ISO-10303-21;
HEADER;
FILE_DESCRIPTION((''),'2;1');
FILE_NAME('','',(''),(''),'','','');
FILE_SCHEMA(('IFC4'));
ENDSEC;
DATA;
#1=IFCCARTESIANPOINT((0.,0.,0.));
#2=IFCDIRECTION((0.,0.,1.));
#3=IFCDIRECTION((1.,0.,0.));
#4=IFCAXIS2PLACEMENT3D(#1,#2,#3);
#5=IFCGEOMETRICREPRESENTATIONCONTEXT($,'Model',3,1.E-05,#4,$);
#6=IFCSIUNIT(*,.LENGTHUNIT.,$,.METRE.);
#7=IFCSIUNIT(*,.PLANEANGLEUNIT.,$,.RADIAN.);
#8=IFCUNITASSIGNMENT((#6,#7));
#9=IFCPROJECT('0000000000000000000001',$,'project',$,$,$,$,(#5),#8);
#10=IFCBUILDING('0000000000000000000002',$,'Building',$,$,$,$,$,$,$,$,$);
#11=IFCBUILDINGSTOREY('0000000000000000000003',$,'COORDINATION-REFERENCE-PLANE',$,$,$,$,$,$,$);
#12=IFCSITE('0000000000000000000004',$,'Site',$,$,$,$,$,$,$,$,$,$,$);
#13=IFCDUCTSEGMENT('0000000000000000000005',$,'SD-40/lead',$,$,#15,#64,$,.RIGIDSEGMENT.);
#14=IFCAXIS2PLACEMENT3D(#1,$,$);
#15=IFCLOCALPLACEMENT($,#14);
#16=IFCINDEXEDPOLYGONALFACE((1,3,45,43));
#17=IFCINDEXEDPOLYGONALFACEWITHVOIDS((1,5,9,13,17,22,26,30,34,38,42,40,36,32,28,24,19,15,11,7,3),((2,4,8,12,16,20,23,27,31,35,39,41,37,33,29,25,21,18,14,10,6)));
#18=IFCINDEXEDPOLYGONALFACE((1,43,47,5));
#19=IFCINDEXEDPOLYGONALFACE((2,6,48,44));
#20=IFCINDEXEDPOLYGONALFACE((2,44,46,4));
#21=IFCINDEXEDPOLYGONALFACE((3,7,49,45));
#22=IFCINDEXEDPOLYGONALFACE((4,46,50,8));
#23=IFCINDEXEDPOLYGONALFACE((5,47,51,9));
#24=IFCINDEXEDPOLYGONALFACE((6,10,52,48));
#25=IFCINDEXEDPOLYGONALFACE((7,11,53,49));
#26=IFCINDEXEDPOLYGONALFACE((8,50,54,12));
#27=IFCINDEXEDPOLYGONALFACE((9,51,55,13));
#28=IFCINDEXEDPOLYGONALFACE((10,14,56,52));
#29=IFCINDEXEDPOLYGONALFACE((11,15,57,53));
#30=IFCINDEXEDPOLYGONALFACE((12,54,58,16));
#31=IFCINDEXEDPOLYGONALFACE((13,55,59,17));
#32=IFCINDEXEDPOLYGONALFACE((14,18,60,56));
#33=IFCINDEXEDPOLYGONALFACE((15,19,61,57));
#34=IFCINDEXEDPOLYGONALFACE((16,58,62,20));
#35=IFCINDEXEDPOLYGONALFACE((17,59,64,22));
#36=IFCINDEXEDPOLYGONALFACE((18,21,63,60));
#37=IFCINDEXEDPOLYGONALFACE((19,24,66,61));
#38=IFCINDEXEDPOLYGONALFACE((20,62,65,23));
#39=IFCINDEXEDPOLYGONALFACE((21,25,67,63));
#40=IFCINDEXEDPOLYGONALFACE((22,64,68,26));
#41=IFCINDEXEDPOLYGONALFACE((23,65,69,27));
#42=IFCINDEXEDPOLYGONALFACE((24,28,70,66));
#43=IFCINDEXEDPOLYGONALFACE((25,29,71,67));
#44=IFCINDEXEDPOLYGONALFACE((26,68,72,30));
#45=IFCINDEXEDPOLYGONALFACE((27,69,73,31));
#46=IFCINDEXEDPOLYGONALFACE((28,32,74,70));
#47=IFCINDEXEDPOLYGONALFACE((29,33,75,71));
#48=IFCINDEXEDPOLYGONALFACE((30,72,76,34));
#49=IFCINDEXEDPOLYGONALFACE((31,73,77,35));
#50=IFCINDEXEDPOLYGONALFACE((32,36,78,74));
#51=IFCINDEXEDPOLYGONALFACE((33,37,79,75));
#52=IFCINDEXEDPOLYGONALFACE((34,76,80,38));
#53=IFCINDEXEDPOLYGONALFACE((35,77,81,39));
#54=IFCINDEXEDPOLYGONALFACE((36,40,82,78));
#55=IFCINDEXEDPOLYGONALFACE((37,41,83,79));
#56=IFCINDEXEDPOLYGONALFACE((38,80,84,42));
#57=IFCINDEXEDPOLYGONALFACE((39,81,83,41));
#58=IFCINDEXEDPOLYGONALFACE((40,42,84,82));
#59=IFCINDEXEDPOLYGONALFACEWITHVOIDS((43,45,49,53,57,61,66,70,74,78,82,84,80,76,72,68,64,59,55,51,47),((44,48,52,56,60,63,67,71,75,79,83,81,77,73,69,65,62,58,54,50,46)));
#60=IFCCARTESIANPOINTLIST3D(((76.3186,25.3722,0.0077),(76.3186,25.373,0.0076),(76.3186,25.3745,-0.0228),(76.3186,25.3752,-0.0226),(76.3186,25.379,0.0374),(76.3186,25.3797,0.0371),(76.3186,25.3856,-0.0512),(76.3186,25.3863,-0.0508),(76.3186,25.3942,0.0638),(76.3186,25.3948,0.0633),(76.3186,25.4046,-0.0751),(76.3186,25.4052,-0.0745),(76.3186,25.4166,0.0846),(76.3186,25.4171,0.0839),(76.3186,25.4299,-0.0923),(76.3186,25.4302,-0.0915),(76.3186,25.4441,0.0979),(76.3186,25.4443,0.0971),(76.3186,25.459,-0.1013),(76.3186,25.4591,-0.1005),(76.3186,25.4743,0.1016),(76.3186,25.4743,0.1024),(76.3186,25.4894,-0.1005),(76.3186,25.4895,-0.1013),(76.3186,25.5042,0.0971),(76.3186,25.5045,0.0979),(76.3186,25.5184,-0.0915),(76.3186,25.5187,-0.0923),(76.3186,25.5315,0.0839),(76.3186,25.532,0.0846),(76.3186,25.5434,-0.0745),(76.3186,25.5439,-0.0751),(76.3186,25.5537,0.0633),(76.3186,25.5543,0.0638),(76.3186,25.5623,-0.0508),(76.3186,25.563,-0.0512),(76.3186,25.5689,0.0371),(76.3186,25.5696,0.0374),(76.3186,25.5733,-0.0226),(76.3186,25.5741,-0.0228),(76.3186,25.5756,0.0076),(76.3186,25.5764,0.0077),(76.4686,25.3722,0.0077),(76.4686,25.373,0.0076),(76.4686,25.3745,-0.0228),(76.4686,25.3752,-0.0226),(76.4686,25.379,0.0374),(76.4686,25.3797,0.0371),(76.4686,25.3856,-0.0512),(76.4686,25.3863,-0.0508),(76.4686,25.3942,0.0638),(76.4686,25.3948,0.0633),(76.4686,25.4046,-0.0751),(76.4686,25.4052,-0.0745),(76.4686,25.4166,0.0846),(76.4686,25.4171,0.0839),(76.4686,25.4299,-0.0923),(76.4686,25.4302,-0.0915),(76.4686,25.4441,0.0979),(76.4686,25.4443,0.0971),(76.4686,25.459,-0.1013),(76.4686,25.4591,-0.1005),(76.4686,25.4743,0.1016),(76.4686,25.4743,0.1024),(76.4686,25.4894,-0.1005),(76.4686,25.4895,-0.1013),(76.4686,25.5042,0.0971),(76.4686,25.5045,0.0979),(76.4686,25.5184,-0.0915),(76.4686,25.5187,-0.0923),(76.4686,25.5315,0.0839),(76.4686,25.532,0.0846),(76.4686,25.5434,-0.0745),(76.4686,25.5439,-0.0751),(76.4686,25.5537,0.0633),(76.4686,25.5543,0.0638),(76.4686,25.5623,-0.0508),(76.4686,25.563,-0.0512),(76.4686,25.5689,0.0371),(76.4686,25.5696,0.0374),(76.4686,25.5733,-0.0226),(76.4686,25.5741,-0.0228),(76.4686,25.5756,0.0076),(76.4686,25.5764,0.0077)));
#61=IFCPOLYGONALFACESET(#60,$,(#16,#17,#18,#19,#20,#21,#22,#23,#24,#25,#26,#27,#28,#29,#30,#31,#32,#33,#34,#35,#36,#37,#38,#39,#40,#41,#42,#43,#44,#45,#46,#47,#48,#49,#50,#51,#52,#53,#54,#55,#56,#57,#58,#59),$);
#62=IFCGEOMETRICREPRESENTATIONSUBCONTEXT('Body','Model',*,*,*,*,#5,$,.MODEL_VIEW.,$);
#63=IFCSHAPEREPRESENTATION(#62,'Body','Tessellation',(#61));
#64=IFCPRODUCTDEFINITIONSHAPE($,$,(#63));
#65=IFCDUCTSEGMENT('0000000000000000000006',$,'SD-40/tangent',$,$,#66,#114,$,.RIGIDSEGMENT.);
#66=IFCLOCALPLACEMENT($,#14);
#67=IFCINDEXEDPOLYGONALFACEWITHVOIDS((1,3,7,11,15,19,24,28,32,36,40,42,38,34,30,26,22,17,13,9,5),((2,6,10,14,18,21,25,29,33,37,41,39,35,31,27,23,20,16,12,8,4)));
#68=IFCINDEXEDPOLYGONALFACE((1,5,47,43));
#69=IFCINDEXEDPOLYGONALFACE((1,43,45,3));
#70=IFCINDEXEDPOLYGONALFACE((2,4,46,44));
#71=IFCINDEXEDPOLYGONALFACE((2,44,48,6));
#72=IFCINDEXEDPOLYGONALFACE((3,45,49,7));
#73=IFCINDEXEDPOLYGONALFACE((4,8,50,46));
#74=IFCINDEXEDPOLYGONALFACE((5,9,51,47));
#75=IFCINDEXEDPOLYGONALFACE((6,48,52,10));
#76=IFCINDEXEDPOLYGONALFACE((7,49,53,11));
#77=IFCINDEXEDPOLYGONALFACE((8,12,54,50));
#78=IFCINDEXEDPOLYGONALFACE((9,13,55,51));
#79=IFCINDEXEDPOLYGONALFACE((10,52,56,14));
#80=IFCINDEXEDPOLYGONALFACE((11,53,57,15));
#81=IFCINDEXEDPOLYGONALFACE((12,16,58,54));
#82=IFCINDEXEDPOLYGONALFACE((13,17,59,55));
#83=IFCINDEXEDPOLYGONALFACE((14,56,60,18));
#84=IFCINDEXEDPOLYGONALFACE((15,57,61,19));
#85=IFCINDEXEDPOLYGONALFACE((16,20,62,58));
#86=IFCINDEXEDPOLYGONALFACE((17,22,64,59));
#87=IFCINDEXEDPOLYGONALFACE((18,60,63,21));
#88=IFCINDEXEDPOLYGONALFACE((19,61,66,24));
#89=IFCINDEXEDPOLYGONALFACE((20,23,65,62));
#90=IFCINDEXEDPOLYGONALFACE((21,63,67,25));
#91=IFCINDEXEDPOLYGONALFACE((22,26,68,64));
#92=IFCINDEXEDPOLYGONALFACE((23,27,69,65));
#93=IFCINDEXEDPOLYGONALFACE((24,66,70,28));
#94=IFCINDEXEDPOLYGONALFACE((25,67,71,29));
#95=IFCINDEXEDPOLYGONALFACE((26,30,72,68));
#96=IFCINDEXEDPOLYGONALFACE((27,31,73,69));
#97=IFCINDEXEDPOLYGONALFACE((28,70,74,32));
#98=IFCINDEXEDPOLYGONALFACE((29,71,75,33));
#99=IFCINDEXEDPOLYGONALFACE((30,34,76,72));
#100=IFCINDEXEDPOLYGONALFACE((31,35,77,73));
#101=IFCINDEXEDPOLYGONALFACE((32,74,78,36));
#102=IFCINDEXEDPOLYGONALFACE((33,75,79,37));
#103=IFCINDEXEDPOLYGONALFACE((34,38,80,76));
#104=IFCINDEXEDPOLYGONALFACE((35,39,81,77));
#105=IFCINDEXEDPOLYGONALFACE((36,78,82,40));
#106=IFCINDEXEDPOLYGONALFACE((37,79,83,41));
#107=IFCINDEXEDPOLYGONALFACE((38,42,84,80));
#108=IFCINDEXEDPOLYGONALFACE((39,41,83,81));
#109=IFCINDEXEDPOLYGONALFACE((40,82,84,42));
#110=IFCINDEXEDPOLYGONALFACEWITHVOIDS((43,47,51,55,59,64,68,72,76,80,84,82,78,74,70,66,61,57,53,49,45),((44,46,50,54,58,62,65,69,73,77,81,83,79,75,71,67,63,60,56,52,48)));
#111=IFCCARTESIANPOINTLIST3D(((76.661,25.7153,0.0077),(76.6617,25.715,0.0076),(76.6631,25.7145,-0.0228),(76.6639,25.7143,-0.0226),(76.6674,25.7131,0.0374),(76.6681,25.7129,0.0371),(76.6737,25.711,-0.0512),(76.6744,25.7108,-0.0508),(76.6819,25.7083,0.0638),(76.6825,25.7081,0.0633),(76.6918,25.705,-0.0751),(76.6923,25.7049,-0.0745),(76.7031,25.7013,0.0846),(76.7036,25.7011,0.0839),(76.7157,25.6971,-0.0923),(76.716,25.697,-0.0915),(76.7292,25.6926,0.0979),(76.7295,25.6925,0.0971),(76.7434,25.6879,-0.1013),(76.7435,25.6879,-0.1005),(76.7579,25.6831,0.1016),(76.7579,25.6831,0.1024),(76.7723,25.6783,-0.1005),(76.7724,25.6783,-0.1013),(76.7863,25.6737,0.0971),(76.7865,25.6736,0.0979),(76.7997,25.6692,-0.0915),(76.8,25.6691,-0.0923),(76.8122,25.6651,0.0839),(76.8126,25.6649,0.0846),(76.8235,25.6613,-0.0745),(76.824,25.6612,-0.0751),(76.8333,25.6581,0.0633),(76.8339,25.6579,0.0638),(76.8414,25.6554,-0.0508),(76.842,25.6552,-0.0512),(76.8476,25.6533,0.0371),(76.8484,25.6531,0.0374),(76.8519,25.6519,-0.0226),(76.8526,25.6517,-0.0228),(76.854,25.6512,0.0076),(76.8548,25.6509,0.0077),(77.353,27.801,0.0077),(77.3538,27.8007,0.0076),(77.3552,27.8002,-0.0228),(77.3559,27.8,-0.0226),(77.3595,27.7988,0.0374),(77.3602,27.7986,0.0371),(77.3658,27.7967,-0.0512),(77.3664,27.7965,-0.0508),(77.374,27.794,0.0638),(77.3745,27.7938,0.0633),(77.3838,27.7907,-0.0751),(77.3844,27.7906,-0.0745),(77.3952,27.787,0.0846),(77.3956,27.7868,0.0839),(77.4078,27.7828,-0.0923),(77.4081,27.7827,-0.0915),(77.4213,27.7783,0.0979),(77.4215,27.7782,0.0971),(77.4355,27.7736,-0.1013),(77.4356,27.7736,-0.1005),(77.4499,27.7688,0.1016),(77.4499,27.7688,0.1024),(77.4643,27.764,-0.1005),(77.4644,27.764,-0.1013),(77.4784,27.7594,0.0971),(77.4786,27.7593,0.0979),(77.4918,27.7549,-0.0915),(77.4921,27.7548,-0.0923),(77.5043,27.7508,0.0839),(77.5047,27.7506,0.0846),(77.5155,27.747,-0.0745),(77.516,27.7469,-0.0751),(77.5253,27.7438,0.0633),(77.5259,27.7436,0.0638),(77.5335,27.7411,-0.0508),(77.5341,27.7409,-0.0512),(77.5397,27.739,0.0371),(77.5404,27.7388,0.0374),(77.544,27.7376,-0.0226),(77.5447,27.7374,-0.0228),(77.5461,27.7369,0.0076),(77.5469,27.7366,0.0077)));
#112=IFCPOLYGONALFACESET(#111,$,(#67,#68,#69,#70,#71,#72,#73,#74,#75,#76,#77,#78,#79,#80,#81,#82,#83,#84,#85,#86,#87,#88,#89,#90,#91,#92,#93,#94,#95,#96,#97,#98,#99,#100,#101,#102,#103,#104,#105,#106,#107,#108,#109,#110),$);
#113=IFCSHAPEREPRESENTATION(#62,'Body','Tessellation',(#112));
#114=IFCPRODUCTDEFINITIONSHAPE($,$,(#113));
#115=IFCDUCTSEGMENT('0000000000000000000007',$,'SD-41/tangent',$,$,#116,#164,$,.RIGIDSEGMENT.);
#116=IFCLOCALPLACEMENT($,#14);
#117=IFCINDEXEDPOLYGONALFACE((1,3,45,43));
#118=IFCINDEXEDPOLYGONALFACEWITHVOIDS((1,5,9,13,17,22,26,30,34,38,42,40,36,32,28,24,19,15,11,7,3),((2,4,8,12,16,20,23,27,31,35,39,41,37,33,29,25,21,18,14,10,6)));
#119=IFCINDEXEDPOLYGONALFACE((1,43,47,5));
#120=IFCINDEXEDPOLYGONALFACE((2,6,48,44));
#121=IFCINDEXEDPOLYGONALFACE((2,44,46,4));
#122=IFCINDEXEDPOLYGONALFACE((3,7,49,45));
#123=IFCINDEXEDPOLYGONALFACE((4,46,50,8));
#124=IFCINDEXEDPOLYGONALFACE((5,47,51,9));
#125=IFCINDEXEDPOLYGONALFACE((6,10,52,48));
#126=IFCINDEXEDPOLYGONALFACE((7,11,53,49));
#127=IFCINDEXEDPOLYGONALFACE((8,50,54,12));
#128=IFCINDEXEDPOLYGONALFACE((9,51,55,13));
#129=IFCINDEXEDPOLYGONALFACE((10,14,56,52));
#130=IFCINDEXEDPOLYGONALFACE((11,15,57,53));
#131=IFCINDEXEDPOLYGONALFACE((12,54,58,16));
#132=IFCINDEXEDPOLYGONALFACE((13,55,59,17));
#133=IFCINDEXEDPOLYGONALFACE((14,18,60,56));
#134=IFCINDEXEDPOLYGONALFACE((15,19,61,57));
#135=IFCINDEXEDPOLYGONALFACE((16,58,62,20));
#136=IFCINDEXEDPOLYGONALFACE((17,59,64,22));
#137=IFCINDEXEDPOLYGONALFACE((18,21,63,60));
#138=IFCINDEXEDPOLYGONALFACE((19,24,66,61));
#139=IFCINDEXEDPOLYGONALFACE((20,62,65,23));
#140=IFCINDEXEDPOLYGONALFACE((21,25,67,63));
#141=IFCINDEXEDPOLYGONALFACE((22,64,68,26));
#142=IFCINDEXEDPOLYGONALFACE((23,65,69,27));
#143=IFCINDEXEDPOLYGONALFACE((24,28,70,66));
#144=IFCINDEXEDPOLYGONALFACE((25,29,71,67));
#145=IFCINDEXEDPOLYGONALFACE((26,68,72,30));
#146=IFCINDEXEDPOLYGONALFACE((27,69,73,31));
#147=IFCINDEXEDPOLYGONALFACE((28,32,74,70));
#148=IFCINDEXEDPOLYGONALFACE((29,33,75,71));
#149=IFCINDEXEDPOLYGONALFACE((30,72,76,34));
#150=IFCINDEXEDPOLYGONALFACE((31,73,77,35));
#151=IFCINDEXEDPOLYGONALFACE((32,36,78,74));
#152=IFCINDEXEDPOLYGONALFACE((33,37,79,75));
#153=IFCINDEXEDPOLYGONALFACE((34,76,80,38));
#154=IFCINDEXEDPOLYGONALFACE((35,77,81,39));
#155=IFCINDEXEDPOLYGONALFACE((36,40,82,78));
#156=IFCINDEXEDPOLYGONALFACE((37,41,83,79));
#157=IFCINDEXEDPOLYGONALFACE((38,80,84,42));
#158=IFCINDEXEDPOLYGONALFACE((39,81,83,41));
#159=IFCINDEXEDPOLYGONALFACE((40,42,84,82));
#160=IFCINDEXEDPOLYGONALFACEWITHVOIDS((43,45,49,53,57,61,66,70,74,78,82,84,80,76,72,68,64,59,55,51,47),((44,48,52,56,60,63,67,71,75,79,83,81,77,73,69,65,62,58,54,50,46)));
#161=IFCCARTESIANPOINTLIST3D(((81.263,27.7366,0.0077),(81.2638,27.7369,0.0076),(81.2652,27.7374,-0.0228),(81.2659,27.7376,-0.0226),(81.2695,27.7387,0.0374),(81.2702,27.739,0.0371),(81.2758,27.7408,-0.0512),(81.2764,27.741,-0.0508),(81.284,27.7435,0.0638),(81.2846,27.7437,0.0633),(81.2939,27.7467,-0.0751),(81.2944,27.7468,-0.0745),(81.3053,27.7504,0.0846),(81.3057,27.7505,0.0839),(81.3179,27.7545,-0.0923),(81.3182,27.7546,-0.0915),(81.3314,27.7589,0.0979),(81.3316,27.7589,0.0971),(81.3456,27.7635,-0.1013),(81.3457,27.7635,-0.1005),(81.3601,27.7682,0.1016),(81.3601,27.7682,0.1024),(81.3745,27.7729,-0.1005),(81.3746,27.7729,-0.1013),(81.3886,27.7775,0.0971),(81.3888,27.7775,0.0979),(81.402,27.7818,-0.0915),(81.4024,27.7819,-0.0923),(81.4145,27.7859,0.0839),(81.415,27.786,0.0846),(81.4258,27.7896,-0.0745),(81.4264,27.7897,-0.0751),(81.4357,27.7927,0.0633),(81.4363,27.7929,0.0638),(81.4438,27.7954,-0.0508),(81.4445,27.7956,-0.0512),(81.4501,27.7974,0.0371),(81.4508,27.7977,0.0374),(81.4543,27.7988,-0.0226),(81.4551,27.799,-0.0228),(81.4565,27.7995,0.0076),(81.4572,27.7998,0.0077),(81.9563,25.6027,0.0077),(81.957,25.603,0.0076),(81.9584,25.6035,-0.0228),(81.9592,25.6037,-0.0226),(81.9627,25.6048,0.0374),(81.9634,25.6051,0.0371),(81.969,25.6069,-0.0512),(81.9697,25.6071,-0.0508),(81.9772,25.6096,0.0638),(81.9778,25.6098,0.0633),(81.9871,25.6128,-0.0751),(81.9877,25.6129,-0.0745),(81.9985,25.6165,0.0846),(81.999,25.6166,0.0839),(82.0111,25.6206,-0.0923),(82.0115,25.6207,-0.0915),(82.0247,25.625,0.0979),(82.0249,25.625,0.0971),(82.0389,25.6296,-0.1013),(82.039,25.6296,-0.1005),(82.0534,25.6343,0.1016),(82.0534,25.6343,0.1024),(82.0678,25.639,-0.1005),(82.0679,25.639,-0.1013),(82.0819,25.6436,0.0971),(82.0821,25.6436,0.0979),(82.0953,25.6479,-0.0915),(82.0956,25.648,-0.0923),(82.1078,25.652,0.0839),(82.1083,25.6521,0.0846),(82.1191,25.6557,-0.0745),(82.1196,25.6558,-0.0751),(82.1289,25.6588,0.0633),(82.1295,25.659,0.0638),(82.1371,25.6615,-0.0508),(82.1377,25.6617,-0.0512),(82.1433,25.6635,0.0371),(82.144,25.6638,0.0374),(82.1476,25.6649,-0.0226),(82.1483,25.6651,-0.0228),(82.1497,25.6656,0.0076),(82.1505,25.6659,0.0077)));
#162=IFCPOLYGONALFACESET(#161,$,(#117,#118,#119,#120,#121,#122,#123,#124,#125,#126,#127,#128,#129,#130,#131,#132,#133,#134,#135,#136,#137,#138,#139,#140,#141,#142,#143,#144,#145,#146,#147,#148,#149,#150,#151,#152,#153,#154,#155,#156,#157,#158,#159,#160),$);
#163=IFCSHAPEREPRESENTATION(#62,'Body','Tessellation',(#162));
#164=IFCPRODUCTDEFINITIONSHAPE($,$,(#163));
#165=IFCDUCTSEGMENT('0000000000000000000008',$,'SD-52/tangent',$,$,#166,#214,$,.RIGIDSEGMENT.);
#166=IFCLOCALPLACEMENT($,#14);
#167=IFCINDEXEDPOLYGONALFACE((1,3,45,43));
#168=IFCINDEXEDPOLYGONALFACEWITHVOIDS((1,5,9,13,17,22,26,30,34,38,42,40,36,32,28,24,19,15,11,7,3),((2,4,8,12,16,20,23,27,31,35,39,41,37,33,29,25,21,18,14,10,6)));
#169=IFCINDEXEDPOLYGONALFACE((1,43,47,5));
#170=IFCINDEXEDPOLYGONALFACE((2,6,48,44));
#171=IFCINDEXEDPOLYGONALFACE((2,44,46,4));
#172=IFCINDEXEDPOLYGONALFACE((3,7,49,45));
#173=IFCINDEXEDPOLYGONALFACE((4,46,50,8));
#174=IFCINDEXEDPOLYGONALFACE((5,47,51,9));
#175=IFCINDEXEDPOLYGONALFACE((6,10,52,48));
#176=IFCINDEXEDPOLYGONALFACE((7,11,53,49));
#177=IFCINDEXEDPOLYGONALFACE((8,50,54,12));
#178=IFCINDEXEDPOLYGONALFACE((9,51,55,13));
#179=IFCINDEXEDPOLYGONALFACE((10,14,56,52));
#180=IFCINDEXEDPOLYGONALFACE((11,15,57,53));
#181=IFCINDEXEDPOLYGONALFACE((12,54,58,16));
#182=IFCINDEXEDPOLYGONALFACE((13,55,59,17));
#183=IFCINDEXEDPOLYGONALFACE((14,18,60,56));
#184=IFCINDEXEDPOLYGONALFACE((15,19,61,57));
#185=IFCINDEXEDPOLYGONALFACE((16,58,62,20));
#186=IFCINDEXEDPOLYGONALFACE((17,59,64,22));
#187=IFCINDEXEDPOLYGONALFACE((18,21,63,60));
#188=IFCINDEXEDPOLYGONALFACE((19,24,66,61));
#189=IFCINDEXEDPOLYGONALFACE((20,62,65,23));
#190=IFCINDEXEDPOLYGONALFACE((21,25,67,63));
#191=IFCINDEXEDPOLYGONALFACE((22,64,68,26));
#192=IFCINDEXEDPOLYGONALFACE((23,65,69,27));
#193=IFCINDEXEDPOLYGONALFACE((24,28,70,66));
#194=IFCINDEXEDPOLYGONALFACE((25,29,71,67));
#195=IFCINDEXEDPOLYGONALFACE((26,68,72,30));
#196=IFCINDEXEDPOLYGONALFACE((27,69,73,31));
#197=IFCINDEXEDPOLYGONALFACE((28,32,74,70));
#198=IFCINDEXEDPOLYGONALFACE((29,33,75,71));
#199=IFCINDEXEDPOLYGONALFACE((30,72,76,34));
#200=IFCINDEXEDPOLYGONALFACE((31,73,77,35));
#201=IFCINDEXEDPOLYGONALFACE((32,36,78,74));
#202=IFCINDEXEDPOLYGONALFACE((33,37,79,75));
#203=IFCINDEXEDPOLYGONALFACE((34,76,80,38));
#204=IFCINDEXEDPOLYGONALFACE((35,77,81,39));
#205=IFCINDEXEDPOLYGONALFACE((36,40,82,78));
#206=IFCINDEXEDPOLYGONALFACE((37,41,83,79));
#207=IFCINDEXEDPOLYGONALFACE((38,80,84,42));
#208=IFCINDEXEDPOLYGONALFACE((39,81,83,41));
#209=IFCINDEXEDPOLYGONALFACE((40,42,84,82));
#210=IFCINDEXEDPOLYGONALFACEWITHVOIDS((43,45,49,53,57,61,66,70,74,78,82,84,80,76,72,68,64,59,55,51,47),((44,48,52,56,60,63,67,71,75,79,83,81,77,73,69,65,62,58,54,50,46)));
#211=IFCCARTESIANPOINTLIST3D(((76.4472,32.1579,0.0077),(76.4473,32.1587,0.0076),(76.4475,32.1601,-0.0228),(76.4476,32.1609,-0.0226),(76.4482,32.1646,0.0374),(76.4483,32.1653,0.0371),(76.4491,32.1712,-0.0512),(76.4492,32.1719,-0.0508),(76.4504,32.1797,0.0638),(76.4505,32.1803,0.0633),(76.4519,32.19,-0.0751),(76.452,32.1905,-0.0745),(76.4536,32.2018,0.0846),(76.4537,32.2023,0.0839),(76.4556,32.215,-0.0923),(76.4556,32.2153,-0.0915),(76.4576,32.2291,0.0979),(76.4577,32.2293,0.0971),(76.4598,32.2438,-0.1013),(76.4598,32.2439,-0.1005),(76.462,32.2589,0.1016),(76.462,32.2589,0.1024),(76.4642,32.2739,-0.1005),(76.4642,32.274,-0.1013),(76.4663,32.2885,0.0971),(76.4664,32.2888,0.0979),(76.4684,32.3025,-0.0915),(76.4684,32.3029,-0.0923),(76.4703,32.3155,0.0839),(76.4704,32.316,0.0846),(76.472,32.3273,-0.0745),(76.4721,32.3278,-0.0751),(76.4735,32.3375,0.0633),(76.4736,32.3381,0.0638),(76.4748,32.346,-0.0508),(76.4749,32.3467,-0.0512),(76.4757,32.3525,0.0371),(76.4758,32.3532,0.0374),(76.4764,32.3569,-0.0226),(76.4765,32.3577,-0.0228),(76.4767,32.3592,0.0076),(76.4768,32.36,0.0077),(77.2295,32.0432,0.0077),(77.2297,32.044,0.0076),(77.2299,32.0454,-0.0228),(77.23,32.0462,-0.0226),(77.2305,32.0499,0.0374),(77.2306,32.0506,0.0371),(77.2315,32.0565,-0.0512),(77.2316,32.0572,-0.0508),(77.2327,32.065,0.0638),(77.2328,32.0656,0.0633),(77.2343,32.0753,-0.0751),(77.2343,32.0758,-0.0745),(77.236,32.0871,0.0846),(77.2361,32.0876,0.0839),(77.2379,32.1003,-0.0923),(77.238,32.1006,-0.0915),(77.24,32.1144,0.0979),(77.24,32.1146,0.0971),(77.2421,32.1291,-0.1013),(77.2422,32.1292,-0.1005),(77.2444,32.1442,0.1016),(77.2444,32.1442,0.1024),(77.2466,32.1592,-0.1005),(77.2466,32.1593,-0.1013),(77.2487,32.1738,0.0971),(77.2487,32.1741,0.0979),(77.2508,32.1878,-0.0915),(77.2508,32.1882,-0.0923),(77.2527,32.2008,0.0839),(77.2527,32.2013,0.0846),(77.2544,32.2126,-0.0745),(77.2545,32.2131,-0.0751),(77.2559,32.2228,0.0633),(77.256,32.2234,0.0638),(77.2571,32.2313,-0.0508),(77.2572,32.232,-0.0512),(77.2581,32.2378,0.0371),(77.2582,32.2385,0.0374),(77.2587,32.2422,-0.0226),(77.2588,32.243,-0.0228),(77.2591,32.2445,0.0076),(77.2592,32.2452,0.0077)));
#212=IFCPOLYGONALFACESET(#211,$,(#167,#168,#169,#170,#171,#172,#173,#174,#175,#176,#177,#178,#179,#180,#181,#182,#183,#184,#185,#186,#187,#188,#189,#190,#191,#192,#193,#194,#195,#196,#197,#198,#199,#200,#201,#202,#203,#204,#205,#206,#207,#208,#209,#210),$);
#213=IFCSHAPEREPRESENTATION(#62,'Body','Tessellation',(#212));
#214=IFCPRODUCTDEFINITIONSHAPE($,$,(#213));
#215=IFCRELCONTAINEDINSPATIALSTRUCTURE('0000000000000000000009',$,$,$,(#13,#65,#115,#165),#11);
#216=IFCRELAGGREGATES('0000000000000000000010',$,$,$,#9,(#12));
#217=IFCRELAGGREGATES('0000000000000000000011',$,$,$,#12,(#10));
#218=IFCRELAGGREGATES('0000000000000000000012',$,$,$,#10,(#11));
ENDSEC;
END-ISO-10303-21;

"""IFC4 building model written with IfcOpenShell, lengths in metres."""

from ifc_helpers import new_model, si_unit, frame, origin_with_axes, place, context, subcontext, project, spatial, hollow_circle, extrude, element, save


model = new_model("IFC4")

# Units and contexts
model_context = context("Model", 3, precision=1e-05, world=origin_with_axes())
body_context_1 = subcontext(model_context, "Body", "Model", "MODEL_VIEW")
ifc_project = project(units=[si_unit("LENGTHUNIT", "METRE"), si_unit("PLANEANGLEUNIT", "RADIAN")], contexts=[model_context])

# Site, building, storey
site = spatial("IfcSite", under=ifc_project, Name="Site")
building = spatial("IfcBuilding", under=site, Name="Building")
storey = spatial("IfcBuildingStorey", under=building, Name="COORDINATION-REFERENCE-PLANE")

# Duct segment
duct_segment_1_placement = place(None, frame((76.3186, 25.4743, 0.0), z_axis=(1.0, 0.0, 0.0), x_axis=(0.0, 0.0, 1.0)))
element("IfcDuctSegment", 1, at=duct_segment_1_placement, inside=storey, Name="SD-40/lead", PredefinedType="RIGIDSEGMENT", context=body_context_1, shape_type="SweptSolid", body=[
    extrude(hollow_circle(Radius=0.1024, WallThickness=0.0008), origin_with_axes(), (0.0, 0.0, 1.0), 0.15),
])

# Duct segment
duct_segment_2_placement = place(None, frame((76.7579, 25.6831, 0.0), z_axis=(0.314929, 0.949115, 0.0), x_axis=(0.0, 0.0, 1.0)))
element("IfcDuctSegment", 2, at=duct_segment_2_placement, inside=storey, Name="SD-40/tangent", PredefinedType="RIGIDSEGMENT", context=body_context_1, shape_type="SweptSolid", body=[
    extrude(hollow_circle(Radius=0.1024, WallThickness=0.0008), origin_with_axes(), (0.0, 0.0, 1.0), 2.1975),
])

# Duct segment
duct_segment_3_placement = place(None, frame((82.0534, 25.6343, 0.0), z_axis=(-0.30899, 0.951065, 0.0), x_axis=(0.0, 0.0, 1.0)))
element("IfcDuctSegment", 3, at=duct_segment_3_placement, inside=storey, Name="SD-41/tangent", PredefinedType="RIGIDSEGMENT", context=body_context_1, shape_type="SweptSolid", body=[
    extrude(hollow_circle(Radius=0.1024, WallThickness=0.0008), origin_with_axes(), (0.0, 0.0, 1.0), 2.2437),
])

# Duct segment
duct_segment_4_placement = place(None, frame((76.462, 32.2589, 0.0), z_axis=(0.989423, -0.145062, 0.0), x_axis=(0.0, 0.0, 1.0)))
element("IfcDuctSegment", 4, at=duct_segment_4_placement, inside=storey, Name="SD-52/tangent", PredefinedType="RIGIDSEGMENT", context=body_context_1, shape_type="SweptSolid", body=[
    extrude(hollow_circle(Radius=0.1024, WallThickness=0.0008), origin_with_axes(), (0.0, 0.0, 1.0), 0.7907),
])

save(model, "model.ifc")
